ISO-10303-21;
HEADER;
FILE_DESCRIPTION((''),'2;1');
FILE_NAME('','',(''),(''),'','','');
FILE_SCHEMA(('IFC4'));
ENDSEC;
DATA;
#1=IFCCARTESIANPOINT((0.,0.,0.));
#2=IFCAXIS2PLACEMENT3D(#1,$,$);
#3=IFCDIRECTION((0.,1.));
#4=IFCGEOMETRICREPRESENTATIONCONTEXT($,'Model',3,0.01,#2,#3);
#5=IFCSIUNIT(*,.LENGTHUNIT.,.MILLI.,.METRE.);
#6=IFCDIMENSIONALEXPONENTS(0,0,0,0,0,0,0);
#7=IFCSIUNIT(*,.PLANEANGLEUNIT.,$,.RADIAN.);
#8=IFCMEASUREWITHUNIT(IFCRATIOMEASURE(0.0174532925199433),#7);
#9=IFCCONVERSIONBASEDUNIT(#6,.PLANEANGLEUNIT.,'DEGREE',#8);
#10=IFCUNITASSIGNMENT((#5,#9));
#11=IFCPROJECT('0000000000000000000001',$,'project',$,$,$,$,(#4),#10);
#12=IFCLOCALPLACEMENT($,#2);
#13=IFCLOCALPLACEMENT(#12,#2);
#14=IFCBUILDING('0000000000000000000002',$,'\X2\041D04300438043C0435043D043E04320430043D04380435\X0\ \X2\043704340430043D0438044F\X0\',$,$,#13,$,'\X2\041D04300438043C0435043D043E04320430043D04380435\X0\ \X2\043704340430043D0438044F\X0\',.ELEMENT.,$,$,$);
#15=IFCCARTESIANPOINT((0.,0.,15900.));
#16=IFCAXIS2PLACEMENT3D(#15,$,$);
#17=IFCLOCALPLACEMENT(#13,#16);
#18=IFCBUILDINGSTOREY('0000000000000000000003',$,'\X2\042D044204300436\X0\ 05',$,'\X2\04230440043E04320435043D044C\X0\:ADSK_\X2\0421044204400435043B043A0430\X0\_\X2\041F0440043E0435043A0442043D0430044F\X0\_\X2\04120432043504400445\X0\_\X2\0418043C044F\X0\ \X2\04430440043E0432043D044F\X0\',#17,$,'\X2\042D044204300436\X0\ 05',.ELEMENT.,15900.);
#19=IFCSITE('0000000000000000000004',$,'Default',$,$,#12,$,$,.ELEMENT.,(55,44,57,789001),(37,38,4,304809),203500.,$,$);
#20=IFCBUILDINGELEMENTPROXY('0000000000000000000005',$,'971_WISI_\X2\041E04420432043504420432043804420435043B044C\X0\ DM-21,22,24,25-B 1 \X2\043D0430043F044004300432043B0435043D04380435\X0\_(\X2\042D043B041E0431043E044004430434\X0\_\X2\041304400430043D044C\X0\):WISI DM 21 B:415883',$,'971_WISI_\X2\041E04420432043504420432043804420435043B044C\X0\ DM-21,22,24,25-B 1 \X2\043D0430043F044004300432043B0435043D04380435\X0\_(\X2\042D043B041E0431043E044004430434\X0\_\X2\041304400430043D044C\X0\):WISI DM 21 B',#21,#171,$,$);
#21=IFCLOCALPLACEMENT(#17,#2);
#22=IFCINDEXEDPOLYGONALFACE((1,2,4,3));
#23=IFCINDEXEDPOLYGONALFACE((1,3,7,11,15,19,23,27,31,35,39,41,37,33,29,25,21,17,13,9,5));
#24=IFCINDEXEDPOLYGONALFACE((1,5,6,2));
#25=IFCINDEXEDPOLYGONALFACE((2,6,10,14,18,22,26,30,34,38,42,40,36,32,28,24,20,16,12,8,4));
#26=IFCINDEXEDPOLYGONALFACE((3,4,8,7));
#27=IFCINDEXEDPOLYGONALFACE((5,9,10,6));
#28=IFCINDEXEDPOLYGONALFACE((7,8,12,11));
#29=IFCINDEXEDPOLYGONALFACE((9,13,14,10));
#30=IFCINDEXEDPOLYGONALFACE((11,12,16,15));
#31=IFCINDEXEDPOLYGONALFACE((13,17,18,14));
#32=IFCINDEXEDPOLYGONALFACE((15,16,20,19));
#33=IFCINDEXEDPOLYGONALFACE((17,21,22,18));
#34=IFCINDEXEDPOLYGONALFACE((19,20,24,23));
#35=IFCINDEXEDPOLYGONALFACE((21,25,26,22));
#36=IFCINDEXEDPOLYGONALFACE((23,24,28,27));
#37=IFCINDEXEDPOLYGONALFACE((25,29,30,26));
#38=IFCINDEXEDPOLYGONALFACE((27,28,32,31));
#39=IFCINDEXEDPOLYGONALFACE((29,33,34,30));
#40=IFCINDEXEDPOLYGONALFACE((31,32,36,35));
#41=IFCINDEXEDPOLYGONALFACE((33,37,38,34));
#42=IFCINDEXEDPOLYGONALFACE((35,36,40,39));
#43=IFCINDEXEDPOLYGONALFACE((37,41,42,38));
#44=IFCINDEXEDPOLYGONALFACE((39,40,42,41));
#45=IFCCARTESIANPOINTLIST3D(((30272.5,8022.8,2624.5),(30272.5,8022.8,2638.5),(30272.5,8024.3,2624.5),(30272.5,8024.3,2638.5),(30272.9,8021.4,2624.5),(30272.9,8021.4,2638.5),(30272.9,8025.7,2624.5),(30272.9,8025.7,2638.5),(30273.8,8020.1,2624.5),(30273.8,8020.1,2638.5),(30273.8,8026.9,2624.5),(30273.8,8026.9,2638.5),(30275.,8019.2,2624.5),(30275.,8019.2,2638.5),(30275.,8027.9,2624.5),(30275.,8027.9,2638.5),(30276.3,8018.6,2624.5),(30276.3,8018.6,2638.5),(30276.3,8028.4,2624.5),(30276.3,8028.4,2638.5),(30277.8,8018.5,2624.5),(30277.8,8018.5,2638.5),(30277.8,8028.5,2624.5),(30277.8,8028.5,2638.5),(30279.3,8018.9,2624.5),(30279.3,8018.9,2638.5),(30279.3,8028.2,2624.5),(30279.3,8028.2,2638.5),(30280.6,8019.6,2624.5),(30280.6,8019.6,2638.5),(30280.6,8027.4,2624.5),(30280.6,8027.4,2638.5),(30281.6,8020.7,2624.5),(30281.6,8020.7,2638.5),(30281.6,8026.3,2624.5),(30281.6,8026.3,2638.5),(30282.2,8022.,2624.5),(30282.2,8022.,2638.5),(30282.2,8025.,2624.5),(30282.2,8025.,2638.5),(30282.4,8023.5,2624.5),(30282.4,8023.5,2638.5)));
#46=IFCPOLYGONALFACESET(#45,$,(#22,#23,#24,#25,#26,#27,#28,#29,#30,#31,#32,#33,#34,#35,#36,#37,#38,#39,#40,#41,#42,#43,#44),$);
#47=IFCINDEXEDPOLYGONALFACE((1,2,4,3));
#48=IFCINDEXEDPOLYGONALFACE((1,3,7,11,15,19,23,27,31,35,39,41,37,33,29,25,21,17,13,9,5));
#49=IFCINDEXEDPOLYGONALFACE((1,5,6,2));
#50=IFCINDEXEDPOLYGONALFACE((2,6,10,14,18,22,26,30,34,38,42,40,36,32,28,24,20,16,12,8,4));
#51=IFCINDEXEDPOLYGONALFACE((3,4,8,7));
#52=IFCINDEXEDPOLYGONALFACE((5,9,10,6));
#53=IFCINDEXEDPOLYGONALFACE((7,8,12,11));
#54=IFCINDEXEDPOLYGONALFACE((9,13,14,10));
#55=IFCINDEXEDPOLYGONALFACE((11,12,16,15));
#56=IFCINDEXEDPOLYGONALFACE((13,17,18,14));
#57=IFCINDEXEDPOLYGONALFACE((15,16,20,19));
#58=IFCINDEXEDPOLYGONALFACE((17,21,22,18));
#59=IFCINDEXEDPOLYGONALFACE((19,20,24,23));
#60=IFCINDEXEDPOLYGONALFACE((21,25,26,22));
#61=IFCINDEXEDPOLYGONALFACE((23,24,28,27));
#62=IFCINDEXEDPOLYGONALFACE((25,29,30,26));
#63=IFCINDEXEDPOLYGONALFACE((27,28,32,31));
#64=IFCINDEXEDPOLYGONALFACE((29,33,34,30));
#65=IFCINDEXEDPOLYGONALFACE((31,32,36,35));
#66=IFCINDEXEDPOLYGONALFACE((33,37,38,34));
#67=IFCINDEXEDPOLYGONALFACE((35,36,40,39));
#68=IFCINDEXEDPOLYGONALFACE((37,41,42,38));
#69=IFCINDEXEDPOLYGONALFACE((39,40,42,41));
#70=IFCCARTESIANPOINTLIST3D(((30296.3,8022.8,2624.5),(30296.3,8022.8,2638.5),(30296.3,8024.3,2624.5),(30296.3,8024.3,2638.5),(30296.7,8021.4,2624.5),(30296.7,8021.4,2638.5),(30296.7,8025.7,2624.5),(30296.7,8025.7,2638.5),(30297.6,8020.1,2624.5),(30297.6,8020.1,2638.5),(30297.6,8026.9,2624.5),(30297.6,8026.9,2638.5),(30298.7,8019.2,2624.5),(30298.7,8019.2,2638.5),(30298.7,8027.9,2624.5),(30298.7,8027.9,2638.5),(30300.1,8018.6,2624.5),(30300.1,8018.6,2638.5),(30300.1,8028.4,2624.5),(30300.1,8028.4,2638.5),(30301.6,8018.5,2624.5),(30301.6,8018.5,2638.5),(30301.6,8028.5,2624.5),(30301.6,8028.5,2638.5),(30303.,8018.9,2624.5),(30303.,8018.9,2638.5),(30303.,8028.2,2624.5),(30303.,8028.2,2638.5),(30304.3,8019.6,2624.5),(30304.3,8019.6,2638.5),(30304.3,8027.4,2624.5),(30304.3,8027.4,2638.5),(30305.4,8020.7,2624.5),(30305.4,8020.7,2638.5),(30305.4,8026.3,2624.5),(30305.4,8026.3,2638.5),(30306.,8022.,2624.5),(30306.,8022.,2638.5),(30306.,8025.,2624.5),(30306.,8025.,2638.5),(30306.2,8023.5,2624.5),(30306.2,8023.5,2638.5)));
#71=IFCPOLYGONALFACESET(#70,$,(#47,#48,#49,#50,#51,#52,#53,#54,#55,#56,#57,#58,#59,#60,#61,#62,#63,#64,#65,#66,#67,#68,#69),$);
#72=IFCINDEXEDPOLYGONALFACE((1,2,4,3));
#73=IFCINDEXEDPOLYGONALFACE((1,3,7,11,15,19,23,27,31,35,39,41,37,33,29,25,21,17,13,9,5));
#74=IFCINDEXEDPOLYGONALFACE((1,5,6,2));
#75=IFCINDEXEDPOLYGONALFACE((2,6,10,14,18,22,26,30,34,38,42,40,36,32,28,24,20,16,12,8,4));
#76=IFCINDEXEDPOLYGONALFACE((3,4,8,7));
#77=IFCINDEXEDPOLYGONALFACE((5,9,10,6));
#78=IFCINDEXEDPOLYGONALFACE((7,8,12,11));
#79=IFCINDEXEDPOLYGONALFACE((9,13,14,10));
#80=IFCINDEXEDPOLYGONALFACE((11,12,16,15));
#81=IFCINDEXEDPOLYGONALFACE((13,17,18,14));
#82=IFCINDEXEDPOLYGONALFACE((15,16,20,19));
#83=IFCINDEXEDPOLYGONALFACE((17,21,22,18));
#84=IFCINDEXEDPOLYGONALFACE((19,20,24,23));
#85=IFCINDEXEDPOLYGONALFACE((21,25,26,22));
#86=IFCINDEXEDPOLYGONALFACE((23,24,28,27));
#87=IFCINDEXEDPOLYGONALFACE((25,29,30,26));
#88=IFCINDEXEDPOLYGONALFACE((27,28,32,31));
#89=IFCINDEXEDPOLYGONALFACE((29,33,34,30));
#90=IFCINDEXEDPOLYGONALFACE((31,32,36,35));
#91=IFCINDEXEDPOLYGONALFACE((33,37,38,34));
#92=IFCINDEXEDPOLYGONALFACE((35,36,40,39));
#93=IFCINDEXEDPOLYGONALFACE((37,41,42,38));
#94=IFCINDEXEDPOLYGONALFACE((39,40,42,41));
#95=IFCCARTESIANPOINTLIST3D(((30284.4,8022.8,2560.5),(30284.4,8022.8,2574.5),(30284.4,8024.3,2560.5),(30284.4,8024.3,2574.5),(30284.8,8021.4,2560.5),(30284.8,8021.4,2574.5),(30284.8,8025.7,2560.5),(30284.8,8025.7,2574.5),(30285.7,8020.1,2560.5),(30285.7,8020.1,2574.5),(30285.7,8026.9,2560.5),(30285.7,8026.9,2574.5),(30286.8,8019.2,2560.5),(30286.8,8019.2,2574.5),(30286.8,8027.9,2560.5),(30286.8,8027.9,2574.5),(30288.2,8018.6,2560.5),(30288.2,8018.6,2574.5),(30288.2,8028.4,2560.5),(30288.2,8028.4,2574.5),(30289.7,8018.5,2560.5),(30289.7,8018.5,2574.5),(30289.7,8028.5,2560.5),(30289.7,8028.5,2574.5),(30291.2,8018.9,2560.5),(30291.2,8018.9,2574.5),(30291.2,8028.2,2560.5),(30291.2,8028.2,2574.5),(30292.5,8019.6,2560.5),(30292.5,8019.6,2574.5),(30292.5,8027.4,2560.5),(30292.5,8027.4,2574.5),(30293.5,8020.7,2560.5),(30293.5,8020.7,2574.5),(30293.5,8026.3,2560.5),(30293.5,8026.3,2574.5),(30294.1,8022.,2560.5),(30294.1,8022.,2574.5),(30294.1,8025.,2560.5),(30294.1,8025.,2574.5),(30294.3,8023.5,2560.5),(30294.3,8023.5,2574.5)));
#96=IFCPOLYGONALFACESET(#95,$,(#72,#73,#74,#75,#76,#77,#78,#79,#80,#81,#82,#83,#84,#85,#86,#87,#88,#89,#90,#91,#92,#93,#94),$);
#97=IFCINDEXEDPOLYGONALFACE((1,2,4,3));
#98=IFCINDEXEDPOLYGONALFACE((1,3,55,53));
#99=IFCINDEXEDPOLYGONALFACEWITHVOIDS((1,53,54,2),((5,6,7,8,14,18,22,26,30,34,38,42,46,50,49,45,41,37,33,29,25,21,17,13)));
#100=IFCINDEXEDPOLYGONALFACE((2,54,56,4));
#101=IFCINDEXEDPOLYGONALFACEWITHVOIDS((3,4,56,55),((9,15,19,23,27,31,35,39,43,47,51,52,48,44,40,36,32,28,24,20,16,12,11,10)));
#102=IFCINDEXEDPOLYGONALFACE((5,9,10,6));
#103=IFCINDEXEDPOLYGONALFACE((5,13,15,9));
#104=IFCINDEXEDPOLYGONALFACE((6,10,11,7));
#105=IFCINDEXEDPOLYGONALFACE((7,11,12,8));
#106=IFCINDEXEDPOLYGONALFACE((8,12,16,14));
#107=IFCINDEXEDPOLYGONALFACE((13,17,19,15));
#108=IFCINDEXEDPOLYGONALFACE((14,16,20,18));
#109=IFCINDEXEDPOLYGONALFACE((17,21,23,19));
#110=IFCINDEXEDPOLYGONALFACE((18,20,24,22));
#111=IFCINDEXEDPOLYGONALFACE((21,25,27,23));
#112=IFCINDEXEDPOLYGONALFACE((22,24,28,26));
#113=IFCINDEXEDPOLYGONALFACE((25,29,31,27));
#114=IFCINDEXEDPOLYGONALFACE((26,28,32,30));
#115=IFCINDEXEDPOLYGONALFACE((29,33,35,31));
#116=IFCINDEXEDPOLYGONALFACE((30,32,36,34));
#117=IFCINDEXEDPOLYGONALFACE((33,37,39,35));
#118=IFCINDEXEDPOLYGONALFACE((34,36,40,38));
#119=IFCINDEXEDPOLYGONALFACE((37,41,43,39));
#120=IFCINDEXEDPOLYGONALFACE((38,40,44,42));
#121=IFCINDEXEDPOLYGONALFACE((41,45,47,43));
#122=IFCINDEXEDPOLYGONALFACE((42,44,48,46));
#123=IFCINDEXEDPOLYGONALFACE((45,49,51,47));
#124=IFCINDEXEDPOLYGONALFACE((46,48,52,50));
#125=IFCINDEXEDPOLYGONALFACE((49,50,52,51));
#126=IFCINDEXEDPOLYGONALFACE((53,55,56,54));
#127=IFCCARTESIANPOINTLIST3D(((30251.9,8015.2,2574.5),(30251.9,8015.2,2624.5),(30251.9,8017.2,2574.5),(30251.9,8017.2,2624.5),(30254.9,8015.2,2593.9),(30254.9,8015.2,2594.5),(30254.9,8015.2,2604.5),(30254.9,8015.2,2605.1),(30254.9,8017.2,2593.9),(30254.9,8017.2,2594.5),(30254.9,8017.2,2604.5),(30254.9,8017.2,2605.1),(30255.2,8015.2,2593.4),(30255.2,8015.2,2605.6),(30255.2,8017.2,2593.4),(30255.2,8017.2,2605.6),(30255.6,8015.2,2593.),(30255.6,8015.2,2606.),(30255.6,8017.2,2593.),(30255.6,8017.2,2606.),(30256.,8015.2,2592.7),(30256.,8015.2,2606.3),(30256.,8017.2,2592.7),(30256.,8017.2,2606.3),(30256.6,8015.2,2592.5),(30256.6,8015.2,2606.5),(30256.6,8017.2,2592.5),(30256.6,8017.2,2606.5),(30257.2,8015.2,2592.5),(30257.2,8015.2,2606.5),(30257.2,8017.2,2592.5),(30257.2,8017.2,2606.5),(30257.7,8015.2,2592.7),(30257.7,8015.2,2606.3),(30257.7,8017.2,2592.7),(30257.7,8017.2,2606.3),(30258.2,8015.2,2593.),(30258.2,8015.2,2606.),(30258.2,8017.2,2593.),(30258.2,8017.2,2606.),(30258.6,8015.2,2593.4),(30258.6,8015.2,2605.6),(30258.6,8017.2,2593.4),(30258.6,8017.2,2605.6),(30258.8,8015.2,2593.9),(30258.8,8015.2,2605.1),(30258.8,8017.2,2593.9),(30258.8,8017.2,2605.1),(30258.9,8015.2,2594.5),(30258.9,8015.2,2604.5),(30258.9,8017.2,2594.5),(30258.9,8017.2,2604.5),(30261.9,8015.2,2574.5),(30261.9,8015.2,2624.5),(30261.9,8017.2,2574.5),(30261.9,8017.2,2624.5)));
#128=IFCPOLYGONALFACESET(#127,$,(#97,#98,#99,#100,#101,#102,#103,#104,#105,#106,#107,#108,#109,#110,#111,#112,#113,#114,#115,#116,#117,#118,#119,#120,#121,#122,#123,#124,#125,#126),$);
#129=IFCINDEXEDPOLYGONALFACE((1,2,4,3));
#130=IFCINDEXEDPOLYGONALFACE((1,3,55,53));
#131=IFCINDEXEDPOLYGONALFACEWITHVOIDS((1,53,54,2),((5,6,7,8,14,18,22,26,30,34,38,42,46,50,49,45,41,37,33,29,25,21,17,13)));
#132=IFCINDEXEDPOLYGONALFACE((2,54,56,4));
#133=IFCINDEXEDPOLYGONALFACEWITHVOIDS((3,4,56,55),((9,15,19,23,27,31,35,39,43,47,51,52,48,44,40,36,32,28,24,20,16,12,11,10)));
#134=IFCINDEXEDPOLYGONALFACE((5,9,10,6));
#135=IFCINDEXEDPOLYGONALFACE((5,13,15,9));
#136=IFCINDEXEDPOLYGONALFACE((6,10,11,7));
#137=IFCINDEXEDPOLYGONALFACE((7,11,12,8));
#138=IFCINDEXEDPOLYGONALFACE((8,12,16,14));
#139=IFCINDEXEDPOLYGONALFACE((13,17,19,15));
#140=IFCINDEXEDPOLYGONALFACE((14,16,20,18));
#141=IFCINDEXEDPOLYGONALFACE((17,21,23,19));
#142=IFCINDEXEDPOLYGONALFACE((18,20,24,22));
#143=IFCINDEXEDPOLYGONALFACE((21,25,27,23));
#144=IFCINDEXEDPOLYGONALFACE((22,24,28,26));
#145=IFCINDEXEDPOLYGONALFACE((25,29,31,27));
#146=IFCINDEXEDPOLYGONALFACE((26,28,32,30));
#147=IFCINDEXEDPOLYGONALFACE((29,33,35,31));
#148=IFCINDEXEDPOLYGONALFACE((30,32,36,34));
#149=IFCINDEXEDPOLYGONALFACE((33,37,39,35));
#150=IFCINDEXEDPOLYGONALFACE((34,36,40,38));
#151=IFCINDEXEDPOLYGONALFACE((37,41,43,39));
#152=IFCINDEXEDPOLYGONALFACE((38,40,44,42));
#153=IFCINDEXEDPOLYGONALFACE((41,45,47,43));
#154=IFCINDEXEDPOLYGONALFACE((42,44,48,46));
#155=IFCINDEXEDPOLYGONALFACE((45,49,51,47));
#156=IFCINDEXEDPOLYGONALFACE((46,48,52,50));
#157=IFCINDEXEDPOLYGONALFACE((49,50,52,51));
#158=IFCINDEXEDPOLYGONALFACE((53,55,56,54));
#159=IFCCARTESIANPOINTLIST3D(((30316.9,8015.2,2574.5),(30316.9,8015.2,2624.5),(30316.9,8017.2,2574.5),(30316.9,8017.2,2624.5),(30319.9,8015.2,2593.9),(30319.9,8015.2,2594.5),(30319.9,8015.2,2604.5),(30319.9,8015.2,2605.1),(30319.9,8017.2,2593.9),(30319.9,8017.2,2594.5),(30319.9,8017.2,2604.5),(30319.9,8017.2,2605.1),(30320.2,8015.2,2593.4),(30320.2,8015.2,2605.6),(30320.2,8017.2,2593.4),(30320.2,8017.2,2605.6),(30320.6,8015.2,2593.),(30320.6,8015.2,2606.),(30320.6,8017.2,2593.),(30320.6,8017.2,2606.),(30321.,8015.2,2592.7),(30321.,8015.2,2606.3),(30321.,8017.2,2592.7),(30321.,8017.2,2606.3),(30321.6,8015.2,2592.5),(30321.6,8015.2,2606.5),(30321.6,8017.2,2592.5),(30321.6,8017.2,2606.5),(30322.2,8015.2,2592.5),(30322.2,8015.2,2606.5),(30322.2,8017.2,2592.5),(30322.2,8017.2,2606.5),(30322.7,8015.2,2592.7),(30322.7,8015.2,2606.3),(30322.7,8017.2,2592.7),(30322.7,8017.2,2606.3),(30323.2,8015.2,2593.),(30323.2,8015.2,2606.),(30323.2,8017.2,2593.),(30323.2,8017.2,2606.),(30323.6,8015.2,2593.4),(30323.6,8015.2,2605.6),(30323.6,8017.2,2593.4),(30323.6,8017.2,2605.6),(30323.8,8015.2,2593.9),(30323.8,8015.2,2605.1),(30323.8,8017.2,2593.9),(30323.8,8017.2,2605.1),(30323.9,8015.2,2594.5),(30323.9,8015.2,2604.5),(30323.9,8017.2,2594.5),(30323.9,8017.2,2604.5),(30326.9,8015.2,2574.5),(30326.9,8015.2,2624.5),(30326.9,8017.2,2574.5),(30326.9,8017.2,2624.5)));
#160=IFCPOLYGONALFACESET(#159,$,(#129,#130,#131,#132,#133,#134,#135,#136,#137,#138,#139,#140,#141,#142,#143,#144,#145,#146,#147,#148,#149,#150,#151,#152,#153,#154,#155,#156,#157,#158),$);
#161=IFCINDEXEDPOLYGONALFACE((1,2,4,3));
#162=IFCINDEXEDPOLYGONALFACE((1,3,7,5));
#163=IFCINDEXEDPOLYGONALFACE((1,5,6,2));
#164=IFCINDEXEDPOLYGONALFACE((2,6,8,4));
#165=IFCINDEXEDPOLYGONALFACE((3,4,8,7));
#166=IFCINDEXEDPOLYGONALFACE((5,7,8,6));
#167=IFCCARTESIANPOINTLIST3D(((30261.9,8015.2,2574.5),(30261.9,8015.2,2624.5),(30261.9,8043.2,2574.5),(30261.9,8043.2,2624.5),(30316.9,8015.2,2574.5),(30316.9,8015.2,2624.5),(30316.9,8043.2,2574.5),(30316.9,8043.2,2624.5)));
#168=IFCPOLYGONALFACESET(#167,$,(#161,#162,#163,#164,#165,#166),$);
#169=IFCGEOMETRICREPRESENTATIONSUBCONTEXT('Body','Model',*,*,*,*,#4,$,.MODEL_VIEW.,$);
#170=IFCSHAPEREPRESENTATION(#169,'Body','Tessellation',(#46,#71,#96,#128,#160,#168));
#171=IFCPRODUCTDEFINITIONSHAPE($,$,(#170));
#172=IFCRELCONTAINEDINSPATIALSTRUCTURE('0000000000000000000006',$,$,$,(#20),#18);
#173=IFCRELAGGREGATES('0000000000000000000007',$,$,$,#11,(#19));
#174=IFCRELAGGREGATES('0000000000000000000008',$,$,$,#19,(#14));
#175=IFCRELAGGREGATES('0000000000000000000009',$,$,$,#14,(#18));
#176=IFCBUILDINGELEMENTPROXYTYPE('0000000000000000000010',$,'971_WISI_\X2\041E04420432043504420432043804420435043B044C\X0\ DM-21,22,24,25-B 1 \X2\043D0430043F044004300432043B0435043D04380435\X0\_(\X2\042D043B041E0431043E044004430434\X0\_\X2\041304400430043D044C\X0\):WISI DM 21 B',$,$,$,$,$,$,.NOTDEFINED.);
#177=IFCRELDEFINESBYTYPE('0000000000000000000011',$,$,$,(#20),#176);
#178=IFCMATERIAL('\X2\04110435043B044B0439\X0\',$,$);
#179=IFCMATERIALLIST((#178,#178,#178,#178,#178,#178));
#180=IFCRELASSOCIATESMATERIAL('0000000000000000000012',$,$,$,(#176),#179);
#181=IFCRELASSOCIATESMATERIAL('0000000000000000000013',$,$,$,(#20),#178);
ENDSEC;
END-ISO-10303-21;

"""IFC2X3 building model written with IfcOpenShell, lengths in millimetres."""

from ifc_helpers import new_model, entity, si_unit, converted_unit, direction, frame, origin, origin_2d_with_axis, place, context, subcontext, project, spatial, rectangle, circle, extrude, source, transform, mapped, material, material_list, type_object, type_shapes, element, save


model = new_model("IFC2X3")

# Units and contexts
model_context = context("Model", 3, precision=0.01, world=origin(), true_north=direction((0.0, 1.0)))
body_context = subcontext(model_context, "Body", "Model", "MODEL_VIEW")
ifc_project = project(units=[si_unit("LENGTHUNIT", "METRE", prefix="MILLI"), converted_unit("PLANEANGLEUNIT", "DEGREE", entity("IfcRatioMeasure", 0.0174532925199433), si_unit("PLANEANGLEUNIT", "RADIAN"), dimensions=[0, 0, 0, 0, 0, 0, 0])], contexts=[model_context])

# Site, building, storey
site_placement = place(None, origin())
site = spatial("IfcSite", under=ifc_project, at=site_placement, Name="Default", CompositionType="ELEMENT", RefLatitude=(55, 44, 57, 789001), RefLongitude=(37, 38, 4, 304809), RefElevation=203500.0)
building_placement = place(site_placement, origin())
building = spatial("IfcBuilding", under=site, at=building_placement, Name="Наименование здания", LongName="Наименование здания", CompositionType="ELEMENT")
storey_placement = place(building_placement, frame((0.0, 0.0, 15900.0)))
storey = spatial("IfcBuildingStorey", under=building, at=storey_placement, Name="Этаж 05", ObjectType="Уровень:ADSK_Стрелка_Проектная_Вверх_Имя уровня", LongName="Этаж 05", CompositionType="ELEMENT", Elevation=15900.0)

# Building element proxy
ifc_material = material(Name="Белый")
ifc_material_list = material_list([ifc_material, ifc_material, ifc_material, ifc_material, ifc_material, ifc_material])
building_element_proxy_type = type_object("IfcBuildingElementProxyType", Name="971_WISI_Ответвитель DM-21,22,24,25-B 1 направление_(ЭлОборуд_Грань):WISI DM 21 B", PredefinedType="NOTDEFINED", material=ifc_material_list)
cartesian_point = entity("IfcCartesianPoint", [-5.0, -25.0])
shared_polyline = entity("IfcPolyline", [cartesian_point, entity("IfcCartesianPoint", [5.0, -25.0]), entity("IfcCartesianPoint", [5.0, 25.0]), entity("IfcCartesianPoint", [-5.0, 25.0]), cartesian_point])
ifc_direction_1 = entity("IfcDirection", [-1.0, 0.0])
ifc_direction_2 = entity("IfcDirection", [0.0, 0.0, 1.0])
ifc_direction_3 = entity("IfcDirection", [-1.0, 0.0])
ifc_direction_4 = entity("IfcDirection", [0.0, 0.0, 1.0])
shared_shape = source(origin(), body_context, "Body", "SweptSolid", [
    extrude(circle(Radius=5.0, at=origin_2d_with_axis()), frame((11.9, 25.0, 8.4), z_axis=(0.0, 1.0, 0.0), x_axis=(-1.0, 0.0, 0.0)), (0.0, 0.0, 1.0), 14.0),
    extrude(circle(Radius=5.0, at=origin_2d_with_axis()), frame((-11.8, 25.0, 8.4), z_axis=(0.0, 1.0, 0.0), x_axis=(-1.0, 0.0, 0.0)), (0.0, 0.0, 1.0), 14.0),
    extrude(circle(Radius=5.0, at=origin_2d_with_axis()), frame((0.0, -39.0, 8.4), z_axis=(0.0, 1.0, 0.0), x_axis=(-1.0, 0.0, 0.0)), (0.0, 0.0, 1.0), 14.0),
    entity("IfcExtrudedAreaSolid", entity("IfcArbitraryProfileDefWithVoids", "AREA", None, shared_polyline, [entity("IfcCompositeCurve", [entity("IfcCompositeCurveSegment", "CONTINUOUS", True, entity("IfcPolyline", [entity("IfcCartesianPoint", [2.0, 5.0]), entity("IfcCartesianPoint", [2.0, -5.0])])), entity("IfcCompositeCurveSegment", "CONTINUOUS", False, entity("IfcTrimmedCurve", entity("IfcCircle", entity("IfcAxis2Placement2D", entity("IfcCartesianPoint", [0.0, -5.0]), ifc_direction_1), 2.0), [entity("IfcParameterValue", 0.0)], [entity("IfcParameterValue", 180.0)], True, "PARAMETER")), entity("IfcCompositeCurveSegment", "CONTINUOUS", True, entity("IfcPolyline", [entity("IfcCartesianPoint", [-2.0, -5.0]), entity("IfcCartesianPoint", [-2.0, 5.0])])), entity("IfcCompositeCurveSegment", "CONTINUOUS", False, entity("IfcTrimmedCurve", entity("IfcCircle", entity("IfcAxis2Placement2D", entity("IfcCartesianPoint", [0.0, 5.0]), ifc_direction_1), 2.0), [entity("IfcParameterValue", 180.0)], [entity("IfcParameterValue", 0.0)], True, "PARAMETER"))], False)]), entity("IfcAxis2Placement3D", entity("IfcCartesianPoint", [32.5, 0.0, 0.0]), ifc_direction_2, entity("IfcDirection", [-1.0, 0.0, 0.0])), ifc_direction_2, 2.0),
    entity("IfcExtrudedAreaSolid", entity("IfcArbitraryProfileDefWithVoids", "AREA", None, shared_polyline, [entity("IfcCompositeCurve", [entity("IfcCompositeCurveSegment", "CONTINUOUS", True, entity("IfcPolyline", [entity("IfcCartesianPoint", [-2.0, -5.0]), entity("IfcCartesianPoint", [-2.0, 5.0])])), entity("IfcCompositeCurveSegment", "CONTINUOUS", False, entity("IfcTrimmedCurve", entity("IfcCircle", entity("IfcAxis2Placement2D", entity("IfcCartesianPoint", [0.0, 5.0]), ifc_direction_3), 2.0), [entity("IfcParameterValue", 180.0)], [entity("IfcParameterValue", 0.0)], True, "PARAMETER")), entity("IfcCompositeCurveSegment", "CONTINUOUS", True, entity("IfcPolyline", [entity("IfcCartesianPoint", [2.0, 5.0]), entity("IfcCartesianPoint", [2.0, -5.0])])), entity("IfcCompositeCurveSegment", "CONTINUOUS", False, entity("IfcTrimmedCurve", entity("IfcCircle", entity("IfcAxis2Placement2D", entity("IfcCartesianPoint", [0.0, -5.0]), ifc_direction_3), 2.0), [entity("IfcParameterValue", 0.0)], [entity("IfcParameterValue", 180.0)], True, "PARAMETER"))], False)]), entity("IfcAxis2Placement3D", entity("IfcCartesianPoint", [-32.5, 0.0, 0.0]), ifc_direction_4, entity("IfcDirection", [-1.0, 0.0, 0.0])), ifc_direction_4, 2.0),
    extrude(rectangle(XDim=55.0, YDim=50.0, at=origin_2d_with_axis()), frame((0.0, 0.0, 0.0), z_axis=(0.0, 0.0, 1.0), x_axis=(-1.0, 0.0, 0.0)), (0.0, 0.0, 1.0), 28.0),
])
type_shapes(building_element_proxy_type, [shared_shape])
for number, where, z_axis, x_axis, name in (
    (1, (30289.4, 8015.1, 2599.5), (0.0, 1.0, 0.0), (-1.0, 0.0, 0.0), "971_WISI_Ответвитель DM-21,22,24,25-B 1 направление_(ЭлОборуд_Грань):WISI DM 21 B:415883"),
):
    element("IfcBuildingElementProxy", number, at=place(storey_placement, frame(where, z_axis=z_axis, x_axis=x_axis)), inside=storey, type_object=building_element_proxy_type, material=ifc_material, Name=name, ObjectType="971_WISI_Ответвитель DM-21,22,24,25-B 1 направление_(ЭлОборуд_Грань):WISI DM 21 B", context=body_context, shape_type="MappedRepresentation", body=[
        mapped(shared_shape, transform((0.0, 0.0, 0.0), scale=1.0)),
    ])

save(model, "model.ifc")
